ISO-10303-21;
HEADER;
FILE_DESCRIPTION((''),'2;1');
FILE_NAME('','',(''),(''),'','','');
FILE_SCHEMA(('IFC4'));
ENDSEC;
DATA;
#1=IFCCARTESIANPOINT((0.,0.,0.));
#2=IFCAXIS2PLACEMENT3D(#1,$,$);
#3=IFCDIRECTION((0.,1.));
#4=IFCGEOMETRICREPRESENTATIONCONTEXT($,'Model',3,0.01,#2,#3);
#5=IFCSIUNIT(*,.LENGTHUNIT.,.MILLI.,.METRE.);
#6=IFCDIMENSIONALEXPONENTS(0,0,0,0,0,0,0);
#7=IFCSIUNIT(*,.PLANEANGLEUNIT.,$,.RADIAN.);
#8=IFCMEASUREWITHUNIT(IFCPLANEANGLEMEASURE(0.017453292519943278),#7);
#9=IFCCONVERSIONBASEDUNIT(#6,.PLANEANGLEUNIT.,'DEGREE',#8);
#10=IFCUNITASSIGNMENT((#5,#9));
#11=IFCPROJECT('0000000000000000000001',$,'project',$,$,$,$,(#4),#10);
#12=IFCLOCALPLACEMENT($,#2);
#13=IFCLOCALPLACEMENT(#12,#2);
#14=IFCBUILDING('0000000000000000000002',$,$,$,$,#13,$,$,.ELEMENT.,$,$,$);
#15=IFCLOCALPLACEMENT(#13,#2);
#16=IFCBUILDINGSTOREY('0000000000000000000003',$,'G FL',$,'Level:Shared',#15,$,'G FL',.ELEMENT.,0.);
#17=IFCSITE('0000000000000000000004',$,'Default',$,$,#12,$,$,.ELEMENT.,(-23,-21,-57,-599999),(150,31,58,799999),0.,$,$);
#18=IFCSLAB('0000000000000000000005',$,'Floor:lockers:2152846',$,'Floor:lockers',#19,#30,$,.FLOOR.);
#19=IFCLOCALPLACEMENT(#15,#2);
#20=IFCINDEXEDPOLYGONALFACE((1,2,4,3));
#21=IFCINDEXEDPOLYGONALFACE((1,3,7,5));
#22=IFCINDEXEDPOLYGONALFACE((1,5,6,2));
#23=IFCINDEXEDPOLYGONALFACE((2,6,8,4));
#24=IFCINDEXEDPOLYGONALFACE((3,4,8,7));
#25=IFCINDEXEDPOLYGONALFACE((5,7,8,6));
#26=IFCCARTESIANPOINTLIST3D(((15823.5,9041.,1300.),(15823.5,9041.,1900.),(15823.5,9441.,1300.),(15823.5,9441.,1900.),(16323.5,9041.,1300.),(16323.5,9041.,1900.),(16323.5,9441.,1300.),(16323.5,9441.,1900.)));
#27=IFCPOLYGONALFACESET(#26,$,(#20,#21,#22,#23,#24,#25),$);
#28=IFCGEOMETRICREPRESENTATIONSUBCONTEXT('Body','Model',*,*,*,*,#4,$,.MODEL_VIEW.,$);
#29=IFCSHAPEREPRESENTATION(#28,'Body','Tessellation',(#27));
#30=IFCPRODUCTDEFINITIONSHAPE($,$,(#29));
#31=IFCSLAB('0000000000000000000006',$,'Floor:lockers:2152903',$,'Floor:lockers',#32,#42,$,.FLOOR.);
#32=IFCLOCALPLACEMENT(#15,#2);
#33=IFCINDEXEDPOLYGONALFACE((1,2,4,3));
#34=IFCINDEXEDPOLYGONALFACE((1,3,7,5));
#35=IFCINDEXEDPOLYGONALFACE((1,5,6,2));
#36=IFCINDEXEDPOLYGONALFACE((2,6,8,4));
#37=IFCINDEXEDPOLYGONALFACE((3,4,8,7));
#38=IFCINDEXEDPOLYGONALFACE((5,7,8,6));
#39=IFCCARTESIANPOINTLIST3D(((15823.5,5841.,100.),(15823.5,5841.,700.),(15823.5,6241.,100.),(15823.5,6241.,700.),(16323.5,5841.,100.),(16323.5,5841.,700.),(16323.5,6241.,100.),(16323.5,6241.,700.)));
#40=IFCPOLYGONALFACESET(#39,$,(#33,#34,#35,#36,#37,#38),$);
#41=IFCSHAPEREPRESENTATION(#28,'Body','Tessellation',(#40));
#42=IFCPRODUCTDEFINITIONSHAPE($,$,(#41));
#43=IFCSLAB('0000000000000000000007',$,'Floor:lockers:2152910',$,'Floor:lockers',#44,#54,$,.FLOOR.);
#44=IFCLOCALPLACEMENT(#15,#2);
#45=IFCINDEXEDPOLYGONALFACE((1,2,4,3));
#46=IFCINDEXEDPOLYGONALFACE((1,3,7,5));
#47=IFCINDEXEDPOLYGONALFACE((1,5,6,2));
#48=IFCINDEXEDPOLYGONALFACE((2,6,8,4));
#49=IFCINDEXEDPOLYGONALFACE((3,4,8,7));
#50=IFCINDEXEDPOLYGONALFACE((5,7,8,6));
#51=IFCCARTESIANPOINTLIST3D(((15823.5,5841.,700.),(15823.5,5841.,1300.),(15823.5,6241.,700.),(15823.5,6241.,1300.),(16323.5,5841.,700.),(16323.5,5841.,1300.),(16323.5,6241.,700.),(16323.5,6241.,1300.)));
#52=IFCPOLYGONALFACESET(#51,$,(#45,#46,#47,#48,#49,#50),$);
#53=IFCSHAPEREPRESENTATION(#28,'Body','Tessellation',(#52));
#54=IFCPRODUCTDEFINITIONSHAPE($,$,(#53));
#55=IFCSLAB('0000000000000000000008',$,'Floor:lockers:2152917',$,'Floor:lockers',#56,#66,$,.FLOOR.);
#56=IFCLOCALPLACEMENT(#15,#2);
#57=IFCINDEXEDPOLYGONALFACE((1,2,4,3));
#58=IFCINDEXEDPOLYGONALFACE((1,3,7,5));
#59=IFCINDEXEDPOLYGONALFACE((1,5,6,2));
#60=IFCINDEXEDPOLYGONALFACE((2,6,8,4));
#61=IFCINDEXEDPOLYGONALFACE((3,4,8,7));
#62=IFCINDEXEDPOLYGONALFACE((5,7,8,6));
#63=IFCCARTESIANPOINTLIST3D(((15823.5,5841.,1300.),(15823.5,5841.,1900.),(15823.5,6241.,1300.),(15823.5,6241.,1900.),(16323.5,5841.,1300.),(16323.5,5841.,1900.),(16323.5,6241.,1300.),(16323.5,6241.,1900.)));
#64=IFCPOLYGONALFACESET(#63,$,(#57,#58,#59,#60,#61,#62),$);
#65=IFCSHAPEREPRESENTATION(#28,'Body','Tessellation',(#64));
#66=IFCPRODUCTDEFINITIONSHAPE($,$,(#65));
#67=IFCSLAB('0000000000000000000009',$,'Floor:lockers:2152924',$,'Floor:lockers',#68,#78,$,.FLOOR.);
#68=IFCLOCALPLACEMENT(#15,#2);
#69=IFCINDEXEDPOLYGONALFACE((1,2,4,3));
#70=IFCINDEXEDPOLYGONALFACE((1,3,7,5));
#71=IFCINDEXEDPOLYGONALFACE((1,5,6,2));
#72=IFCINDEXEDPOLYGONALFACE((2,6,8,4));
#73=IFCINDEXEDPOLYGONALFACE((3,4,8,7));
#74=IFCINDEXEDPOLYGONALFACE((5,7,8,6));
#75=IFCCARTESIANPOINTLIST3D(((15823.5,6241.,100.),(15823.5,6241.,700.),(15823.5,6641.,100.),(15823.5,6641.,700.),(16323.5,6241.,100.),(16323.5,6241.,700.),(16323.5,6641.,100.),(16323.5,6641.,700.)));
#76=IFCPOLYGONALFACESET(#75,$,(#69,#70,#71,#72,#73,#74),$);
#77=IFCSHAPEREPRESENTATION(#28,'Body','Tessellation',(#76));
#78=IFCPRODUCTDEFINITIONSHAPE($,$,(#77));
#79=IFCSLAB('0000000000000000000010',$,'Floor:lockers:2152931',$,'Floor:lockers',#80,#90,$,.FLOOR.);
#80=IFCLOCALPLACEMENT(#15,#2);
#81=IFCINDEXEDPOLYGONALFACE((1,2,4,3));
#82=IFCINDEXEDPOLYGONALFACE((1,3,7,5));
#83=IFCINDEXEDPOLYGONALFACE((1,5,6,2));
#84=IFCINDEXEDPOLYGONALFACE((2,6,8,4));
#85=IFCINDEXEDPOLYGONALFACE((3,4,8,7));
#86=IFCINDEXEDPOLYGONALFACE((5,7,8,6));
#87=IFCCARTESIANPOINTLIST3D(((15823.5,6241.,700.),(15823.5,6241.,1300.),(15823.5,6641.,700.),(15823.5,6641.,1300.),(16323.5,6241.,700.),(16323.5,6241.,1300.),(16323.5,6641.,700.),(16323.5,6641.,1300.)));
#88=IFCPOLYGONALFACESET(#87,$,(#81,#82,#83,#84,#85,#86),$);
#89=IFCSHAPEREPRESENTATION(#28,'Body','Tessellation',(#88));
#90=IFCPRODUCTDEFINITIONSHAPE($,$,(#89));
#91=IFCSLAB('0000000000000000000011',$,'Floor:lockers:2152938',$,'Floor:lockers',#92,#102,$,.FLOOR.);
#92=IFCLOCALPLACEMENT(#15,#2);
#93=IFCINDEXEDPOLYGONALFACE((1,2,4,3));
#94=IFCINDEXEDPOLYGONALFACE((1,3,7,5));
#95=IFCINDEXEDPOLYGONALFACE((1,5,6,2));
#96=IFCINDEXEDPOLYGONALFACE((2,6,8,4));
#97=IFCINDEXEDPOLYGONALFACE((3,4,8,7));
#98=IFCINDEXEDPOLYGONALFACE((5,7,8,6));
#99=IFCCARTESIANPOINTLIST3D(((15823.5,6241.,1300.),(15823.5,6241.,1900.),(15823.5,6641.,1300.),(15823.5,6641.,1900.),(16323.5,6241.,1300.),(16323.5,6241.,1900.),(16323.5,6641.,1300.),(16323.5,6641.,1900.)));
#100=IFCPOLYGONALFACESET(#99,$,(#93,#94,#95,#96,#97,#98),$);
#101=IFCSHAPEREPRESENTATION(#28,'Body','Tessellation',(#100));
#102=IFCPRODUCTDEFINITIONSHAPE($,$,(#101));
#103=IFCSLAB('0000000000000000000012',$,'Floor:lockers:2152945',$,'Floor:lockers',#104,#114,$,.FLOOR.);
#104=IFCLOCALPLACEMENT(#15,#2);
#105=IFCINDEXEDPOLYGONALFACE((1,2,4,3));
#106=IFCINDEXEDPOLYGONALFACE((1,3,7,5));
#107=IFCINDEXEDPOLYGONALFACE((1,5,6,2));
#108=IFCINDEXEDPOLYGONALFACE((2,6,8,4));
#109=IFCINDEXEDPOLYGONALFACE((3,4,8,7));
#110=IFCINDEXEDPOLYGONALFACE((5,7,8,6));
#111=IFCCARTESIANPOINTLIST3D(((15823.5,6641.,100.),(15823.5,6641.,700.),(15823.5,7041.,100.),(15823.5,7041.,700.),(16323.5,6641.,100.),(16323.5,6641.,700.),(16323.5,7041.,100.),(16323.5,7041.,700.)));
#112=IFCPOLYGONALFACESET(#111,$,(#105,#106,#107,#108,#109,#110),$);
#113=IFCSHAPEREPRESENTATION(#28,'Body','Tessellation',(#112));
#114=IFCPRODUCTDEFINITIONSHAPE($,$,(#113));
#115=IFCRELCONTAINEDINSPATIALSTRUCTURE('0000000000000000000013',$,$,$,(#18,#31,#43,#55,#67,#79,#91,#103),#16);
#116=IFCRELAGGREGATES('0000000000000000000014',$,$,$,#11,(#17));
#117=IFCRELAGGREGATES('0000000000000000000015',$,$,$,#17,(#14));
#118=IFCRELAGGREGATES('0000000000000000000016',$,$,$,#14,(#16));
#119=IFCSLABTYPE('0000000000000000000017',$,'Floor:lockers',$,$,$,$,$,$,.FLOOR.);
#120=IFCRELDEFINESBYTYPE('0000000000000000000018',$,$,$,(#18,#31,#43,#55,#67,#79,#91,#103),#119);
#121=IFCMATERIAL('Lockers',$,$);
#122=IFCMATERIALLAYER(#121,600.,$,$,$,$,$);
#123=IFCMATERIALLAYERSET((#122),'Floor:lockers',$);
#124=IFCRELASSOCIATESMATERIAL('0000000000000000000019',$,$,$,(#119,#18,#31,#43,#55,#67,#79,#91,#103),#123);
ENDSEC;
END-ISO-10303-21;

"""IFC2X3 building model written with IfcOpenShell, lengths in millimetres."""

from ifc_helpers import new_model, entity, si_unit, converted_unit, direction, frame, frame_2d, origin, place, context, subcontext, project, spatial, rectangle, extrude, material, layer, layer_set, layer_usage, type_object, element, save


model = new_model("IFC2X3")

# Units and contexts
model_context = context("Model", 3, precision=0.01, world=origin(), true_north=direction((0.0, 1.0)))
body_context = subcontext(model_context, "Body", "Model", "MODEL_VIEW")
ifc_project = project(units=[si_unit("LENGTHUNIT", "METRE", prefix="MILLI"), converted_unit("PLANEANGLEUNIT", "DEGREE", entity("IfcPlaneAngleMeasure", 0.017453292519943278), si_unit("PLANEANGLEUNIT", "RADIAN"), dimensions=[0, 0, 0, 0, 0, 0, 0])], contexts=[model_context])

# Site, building, storey
site_placement = place(None, origin())
site = spatial("IfcSite", under=ifc_project, at=site_placement, Name="Default", CompositionType="ELEMENT", RefLatitude=(-23, -21, -57, -599999), RefLongitude=(150, 31, 58, 799999), RefElevation=0.0)
building_placement = place(site_placement, origin())
building = spatial("IfcBuilding", under=site, at=building_placement, CompositionType="ELEMENT")
storey_placement = place(building_placement, origin())
storey = spatial("IfcBuildingStorey", under=building, at=storey_placement, Name="G FL", ObjectType="Level:Shared", LongName="G FL", CompositionType="ELEMENT", Elevation=0.0)

# Slabs
ifc_material = material(Name="Lockers")
ifc_layer = layer(ifc_material, 600.0)
ifc_layer_set = layer_set([ifc_layer], Name="Floor:lockers")
slab_type = type_object("IfcSlabType", Name="Floor:lockers", PredefinedType="FLOOR", material=ifc_layer_set)
ifc_layer_usage_1 = layer_usage(ifc_layer_set, "AXIS3", "POSITIVE", 0.0)
slab_1_placement = place(storey_placement, origin())
element("IfcSlab", 1, at=slab_1_placement, inside=storey, type_object=slab_type, material=ifc_layer_usage_1, Name="Floor:lockers:2152846", ObjectType="Floor:lockers", PredefinedType="FLOOR", context=body_context, shape_type="SweptSolid", body=[
    extrude(rectangle(XDim=400.0, YDim=500.0, at=frame_2d((0.0, 0.0), x_axis=(1.0, 0.0))), frame((16073.5, 9241.0, 1900.0), z_axis=(0.0, 0.0, -1.0), x_axis=(0.0, 1.0, 0.0)), (0.0, 0.0, 1.0), 600.0),
])
ifc_layer_usage_2 = layer_usage(ifc_layer_set, "AXIS3", "POSITIVE", 0.0)
slab_2_placement = place(storey_placement, origin())
element("IfcSlab", 2, at=slab_2_placement, inside=storey, type_object=slab_type, material=ifc_layer_usage_2, Name="Floor:lockers:2152903", ObjectType="Floor:lockers", PredefinedType="FLOOR", context=body_context, shape_type="SweptSolid", body=[
    extrude(rectangle(XDim=400.0, YDim=500.0, at=frame_2d((0.0, 0.0), x_axis=(1.0, 0.0))), frame((16073.5, 6041.0, 700.0), z_axis=(0.0, 0.0, -1.0), x_axis=(0.0, 1.0, 0.0)), (0.0, 0.0, 1.0), 600.0),
])
ifc_layer_usage_3 = layer_usage(ifc_layer_set, "AXIS3", "POSITIVE", 0.0)
slab_3_placement = place(storey_placement, origin())
element("IfcSlab", 3, at=slab_3_placement, inside=storey, type_object=slab_type, material=ifc_layer_usage_3, Name="Floor:lockers:2152910", ObjectType="Floor:lockers", PredefinedType="FLOOR", context=body_context, shape_type="SweptSolid", body=[
    extrude(rectangle(XDim=400.0, YDim=500.0, at=frame_2d((0.0, 0.0), x_axis=(1.0, 0.0))), frame((16073.5, 6041.0, 1300.0), z_axis=(0.0, 0.0, -1.0), x_axis=(0.0, 1.0, 0.0)), (0.0, 0.0, 1.0), 600.0),
])
ifc_layer_usage_4 = layer_usage(ifc_layer_set, "AXIS3", "POSITIVE", 0.0)
slab_4_placement = place(storey_placement, origin())
element("IfcSlab", 4, at=slab_4_placement, inside=storey, type_object=slab_type, material=ifc_layer_usage_4, Name="Floor:lockers:2152917", ObjectType="Floor:lockers", PredefinedType="FLOOR", context=body_context, shape_type="SweptSolid", body=[
    extrude(rectangle(XDim=400.0, YDim=500.0, at=frame_2d((0.0, 0.0), x_axis=(1.0, 0.0))), frame((16073.5, 6041.0, 1900.0), z_axis=(0.0, 0.0, -1.0), x_axis=(0.0, 1.0, 0.0)), (0.0, 0.0, 1.0), 600.0),
])
ifc_layer_usage_5 = layer_usage(ifc_layer_set, "AXIS3", "POSITIVE", 0.0)
slab_5_placement = place(storey_placement, origin())
element("IfcSlab", 5, at=slab_5_placement, inside=storey, type_object=slab_type, material=ifc_layer_usage_5, Name="Floor:lockers:2152924", ObjectType="Floor:lockers", PredefinedType="FLOOR", context=body_context, shape_type="SweptSolid", body=[
    extrude(rectangle(XDim=400.0, YDim=500.0, at=frame_2d((0.0, 0.0), x_axis=(1.0, 0.0))), frame((16073.5, 6441.0, 700.0), z_axis=(0.0, 0.0, -1.0), x_axis=(0.0, 1.0, 0.0)), (0.0, 0.0, 1.0), 600.0),
])
ifc_layer_usage_6 = layer_usage(ifc_layer_set, "AXIS3", "POSITIVE", 0.0)
slab_6_placement = place(storey_placement, origin())
element("IfcSlab", 6, at=slab_6_placement, inside=storey, type_object=slab_type, material=ifc_layer_usage_6, Name="Floor:lockers:2152931", ObjectType="Floor:lockers", PredefinedType="FLOOR", context=body_context, shape_type="SweptSolid", body=[
    extrude(rectangle(XDim=400.0, YDim=500.0, at=frame_2d((0.0, 0.0), x_axis=(1.0, 0.0))), frame((16073.5, 6441.0, 1300.0), z_axis=(0.0, 0.0, -1.0), x_axis=(0.0, 1.0, 0.0)), (0.0, 0.0, 1.0), 600.0),
])
ifc_layer_usage_7 = layer_usage(ifc_layer_set, "AXIS3", "POSITIVE", 0.0)
slab_7_placement = place(storey_placement, origin())
element("IfcSlab", 7, at=slab_7_placement, inside=storey, type_object=slab_type, material=ifc_layer_usage_7, Name="Floor:lockers:2152938", ObjectType="Floor:lockers", PredefinedType="FLOOR", context=body_context, shape_type="SweptSolid", body=[
    extrude(rectangle(XDim=400.0, YDim=500.0, at=frame_2d((0.0, 0.0), x_axis=(1.0, 0.0))), frame((16073.5, 6441.0, 1900.0), z_axis=(0.0, 0.0, -1.0), x_axis=(0.0, 1.0, 0.0)), (0.0, 0.0, 1.0), 600.0),
])
ifc_layer_usage_8 = layer_usage(ifc_layer_set, "AXIS3", "POSITIVE", 0.0)
slab_8_placement = place(storey_placement, origin())
element("IfcSlab", 8, at=slab_8_placement, inside=storey, type_object=slab_type, material=ifc_layer_usage_8, Name="Floor:lockers:2152945", ObjectType="Floor:lockers", PredefinedType="FLOOR", context=body_context, shape_type="SweptSolid", body=[
    extrude(rectangle(XDim=400.0, YDim=500.0, at=frame_2d((0.0, 0.0), x_axis=(1.0, 0.0))), frame((16073.5, 6841.0, 700.0), z_axis=(0.0, 0.0, -1.0), x_axis=(0.0, 1.0, 0.0)), (0.0, 0.0, 1.0), 600.0),
])

save(model, "model.ifc")
